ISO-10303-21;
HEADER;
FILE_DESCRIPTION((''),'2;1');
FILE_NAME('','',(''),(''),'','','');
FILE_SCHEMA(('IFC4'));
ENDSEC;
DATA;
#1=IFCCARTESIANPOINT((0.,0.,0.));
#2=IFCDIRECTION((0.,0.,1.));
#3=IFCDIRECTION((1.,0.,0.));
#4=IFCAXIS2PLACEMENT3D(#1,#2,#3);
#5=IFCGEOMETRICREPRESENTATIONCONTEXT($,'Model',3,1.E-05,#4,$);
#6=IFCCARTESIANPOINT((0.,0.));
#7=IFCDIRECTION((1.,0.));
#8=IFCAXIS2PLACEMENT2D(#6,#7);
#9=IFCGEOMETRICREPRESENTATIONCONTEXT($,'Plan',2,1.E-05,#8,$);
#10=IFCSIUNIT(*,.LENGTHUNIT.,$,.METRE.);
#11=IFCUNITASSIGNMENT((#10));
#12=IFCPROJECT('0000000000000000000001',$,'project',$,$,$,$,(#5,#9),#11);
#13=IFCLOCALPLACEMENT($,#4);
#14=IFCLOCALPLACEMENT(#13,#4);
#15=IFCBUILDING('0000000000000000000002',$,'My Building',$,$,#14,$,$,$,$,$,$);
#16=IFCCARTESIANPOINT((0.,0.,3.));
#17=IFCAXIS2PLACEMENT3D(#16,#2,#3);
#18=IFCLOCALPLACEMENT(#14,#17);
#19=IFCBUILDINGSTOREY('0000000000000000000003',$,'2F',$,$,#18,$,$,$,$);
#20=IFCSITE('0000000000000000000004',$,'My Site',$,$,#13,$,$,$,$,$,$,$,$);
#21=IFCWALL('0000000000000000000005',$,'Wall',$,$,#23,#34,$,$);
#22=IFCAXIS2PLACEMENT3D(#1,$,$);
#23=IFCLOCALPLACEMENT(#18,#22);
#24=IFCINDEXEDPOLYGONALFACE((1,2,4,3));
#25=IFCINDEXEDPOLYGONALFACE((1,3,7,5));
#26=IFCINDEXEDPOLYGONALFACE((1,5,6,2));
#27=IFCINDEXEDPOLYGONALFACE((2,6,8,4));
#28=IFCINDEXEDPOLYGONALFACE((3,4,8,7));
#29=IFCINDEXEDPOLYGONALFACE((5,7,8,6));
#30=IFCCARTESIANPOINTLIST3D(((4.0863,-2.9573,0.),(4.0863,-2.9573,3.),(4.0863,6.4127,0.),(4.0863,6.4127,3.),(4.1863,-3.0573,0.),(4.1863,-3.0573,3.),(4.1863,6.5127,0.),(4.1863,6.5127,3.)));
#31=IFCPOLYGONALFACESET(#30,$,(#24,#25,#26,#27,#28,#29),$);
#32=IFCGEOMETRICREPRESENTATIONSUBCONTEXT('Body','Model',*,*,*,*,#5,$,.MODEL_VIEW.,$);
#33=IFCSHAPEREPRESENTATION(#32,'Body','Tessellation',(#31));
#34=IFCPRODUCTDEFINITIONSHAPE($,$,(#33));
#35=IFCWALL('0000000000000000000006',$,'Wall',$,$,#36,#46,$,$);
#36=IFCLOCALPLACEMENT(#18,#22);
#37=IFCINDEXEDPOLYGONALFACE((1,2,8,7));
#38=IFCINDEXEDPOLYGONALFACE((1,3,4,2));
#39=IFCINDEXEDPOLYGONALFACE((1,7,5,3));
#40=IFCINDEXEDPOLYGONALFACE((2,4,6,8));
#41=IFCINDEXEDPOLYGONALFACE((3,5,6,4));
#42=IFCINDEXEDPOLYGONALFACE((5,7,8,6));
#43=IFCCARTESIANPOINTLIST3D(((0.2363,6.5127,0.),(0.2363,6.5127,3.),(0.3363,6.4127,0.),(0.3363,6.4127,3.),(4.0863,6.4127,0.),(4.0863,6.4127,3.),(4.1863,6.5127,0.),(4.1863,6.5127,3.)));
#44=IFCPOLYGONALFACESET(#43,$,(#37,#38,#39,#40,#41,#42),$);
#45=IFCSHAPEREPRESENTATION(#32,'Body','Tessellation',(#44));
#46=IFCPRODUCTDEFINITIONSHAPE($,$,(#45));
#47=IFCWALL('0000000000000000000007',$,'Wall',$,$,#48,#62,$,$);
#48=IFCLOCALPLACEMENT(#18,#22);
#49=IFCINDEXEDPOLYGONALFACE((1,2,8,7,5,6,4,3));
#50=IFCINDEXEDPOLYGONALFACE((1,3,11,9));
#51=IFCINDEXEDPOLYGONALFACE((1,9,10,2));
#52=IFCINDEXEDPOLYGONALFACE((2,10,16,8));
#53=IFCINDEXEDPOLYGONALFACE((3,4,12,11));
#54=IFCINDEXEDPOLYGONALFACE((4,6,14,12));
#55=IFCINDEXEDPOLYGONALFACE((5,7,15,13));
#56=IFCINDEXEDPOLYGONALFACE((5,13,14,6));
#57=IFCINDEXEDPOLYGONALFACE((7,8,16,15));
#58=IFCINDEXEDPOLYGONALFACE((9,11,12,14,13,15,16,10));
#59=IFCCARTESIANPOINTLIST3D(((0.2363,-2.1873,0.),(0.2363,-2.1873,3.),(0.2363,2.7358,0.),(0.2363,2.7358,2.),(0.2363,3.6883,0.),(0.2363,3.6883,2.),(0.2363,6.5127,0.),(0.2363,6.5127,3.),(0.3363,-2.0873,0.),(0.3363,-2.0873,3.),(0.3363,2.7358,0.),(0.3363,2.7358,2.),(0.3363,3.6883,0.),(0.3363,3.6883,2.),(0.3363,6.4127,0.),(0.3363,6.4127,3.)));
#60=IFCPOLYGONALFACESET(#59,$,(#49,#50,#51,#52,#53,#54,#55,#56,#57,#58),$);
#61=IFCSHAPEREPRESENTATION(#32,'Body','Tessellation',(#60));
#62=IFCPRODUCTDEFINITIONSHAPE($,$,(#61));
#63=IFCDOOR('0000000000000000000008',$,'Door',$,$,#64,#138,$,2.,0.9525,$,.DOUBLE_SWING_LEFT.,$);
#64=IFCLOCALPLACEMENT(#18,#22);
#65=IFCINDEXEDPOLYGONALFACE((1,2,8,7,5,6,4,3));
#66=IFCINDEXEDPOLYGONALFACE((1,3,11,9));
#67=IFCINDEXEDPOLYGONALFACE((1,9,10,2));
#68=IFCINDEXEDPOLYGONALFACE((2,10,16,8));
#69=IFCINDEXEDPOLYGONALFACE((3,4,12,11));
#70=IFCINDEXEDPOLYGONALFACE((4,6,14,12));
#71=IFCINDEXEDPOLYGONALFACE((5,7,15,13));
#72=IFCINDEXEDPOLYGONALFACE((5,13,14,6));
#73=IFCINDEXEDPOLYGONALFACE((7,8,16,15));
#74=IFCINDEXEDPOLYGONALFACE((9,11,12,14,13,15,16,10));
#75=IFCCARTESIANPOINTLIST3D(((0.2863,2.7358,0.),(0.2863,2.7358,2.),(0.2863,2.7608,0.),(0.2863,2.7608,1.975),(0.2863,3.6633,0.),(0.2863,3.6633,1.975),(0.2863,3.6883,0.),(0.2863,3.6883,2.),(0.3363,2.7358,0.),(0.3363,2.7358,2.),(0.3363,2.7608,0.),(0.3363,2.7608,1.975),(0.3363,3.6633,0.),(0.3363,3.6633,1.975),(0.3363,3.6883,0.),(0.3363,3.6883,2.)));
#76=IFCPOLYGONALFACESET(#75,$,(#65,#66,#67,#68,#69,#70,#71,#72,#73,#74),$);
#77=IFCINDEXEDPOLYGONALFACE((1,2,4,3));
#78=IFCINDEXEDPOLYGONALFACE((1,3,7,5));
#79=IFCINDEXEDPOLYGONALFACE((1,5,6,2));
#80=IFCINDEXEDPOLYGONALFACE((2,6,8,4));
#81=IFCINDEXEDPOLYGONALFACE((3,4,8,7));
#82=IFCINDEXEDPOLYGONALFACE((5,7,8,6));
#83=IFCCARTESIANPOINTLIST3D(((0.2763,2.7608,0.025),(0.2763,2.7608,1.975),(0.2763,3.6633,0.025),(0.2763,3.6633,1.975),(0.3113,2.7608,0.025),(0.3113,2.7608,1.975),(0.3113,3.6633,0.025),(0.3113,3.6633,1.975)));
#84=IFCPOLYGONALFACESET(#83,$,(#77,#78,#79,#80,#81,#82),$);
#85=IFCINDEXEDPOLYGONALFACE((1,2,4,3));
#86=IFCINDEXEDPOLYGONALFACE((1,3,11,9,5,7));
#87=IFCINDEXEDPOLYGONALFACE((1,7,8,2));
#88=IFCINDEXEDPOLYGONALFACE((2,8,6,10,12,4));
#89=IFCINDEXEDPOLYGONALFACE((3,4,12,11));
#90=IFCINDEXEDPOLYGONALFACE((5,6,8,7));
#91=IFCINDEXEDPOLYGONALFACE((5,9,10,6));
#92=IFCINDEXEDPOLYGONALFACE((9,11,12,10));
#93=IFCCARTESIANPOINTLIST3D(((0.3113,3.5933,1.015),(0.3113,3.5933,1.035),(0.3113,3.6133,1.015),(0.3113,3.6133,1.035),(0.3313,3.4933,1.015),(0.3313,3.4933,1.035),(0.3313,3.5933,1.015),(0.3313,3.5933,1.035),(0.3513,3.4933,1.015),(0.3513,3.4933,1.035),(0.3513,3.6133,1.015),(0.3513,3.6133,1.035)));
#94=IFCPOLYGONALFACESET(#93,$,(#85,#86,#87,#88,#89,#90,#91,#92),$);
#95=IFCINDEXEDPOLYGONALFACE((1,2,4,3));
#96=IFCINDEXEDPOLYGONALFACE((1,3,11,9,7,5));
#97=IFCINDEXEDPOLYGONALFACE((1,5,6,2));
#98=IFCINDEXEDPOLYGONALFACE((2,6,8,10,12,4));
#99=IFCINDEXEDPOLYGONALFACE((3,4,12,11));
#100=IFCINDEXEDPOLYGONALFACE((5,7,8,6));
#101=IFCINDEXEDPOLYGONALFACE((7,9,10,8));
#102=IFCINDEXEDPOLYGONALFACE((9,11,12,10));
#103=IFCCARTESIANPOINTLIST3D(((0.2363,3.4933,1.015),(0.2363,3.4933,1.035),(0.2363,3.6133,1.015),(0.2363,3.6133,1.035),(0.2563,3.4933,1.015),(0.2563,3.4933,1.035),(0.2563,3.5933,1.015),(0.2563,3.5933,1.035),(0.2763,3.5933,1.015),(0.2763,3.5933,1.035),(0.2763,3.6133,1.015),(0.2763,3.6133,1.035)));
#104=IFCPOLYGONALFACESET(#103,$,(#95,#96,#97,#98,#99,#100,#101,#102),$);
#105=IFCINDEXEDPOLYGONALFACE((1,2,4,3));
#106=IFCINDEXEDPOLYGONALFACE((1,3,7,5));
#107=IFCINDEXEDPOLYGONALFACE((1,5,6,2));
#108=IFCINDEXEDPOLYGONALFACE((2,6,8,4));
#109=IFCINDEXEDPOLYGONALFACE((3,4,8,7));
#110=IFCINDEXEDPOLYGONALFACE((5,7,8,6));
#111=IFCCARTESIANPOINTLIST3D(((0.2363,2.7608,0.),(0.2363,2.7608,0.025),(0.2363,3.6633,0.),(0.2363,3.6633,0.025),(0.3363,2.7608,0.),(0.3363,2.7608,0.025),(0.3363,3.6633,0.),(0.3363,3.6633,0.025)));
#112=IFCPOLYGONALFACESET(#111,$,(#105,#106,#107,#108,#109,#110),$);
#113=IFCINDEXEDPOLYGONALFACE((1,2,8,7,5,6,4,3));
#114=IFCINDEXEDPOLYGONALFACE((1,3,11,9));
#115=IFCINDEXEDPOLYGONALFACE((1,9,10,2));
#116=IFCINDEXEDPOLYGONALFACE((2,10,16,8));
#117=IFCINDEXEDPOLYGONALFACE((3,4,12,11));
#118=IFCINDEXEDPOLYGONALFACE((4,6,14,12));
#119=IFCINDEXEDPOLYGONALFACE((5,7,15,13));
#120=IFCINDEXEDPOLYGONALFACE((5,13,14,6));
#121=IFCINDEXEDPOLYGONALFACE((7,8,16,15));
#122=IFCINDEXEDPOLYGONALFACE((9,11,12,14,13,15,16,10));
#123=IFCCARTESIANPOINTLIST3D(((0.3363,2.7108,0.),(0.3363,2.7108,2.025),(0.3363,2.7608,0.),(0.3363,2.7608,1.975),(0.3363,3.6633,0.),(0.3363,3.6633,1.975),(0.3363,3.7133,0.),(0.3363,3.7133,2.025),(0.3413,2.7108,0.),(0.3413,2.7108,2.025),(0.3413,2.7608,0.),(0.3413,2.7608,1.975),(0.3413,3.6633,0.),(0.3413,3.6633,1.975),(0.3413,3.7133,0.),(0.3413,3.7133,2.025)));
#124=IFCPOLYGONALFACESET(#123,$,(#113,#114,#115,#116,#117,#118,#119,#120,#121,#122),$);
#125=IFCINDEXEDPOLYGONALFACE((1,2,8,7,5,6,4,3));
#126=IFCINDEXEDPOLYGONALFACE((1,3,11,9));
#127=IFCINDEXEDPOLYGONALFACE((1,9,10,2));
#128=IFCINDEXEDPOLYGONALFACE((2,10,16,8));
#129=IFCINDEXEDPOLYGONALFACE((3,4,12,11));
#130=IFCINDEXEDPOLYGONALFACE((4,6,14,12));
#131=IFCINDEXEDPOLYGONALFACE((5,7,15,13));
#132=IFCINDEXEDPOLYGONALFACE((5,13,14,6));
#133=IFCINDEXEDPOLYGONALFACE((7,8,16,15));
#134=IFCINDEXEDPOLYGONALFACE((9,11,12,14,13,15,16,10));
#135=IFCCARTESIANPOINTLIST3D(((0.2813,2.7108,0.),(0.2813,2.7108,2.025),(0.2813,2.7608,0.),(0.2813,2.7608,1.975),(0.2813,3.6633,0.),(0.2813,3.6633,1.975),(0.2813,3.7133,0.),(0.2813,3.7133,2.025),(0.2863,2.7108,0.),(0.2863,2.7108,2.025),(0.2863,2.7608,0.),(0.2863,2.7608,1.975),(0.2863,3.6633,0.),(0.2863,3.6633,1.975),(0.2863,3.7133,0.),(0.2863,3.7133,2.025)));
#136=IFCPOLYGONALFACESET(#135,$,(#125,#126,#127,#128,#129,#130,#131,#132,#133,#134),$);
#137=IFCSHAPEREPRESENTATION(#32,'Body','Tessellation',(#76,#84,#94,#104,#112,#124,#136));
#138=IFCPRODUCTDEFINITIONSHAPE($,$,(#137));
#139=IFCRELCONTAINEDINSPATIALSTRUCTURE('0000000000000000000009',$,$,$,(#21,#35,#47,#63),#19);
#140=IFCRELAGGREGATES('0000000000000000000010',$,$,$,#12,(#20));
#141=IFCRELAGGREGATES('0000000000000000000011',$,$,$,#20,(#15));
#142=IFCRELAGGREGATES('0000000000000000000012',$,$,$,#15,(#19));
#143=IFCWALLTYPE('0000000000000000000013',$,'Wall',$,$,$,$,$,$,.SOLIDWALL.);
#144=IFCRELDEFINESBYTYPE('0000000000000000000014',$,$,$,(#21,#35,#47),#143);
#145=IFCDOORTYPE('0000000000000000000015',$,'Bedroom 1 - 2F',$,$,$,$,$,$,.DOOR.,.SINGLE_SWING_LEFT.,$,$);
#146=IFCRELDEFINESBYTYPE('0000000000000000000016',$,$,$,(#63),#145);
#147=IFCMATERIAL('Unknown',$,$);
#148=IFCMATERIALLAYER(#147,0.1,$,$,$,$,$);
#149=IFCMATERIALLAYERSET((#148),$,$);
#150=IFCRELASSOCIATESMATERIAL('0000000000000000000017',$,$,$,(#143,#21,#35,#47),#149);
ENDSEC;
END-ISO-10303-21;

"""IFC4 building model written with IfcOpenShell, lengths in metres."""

from ifc_helpers import new_model, entity, si_unit, frame, origin_with_axes, origin_2d_with_axis, place, context, subcontext, project, spatial, line, indexed_curve, outline, extrude, shape, source, transform, mapped, material, layer, layer_set, layer_usage, type_object, type_shapes, element, fill, save


model = new_model("IFC4")

# Units and contexts
model_context = context("Model", 3, precision=1e-05, world=origin_with_axes())
plan_context = context("Plan", 2, precision=1e-05, world=origin_2d_with_axis())
body_context_1 = subcontext(model_context, "Body", "Model", "MODEL_VIEW")
body_context_2 = subcontext(plan_context, "Body", "Plan", "PLAN_VIEW")
ifc_project = project(units=[si_unit("LENGTHUNIT", "METRE")], contexts=[model_context, plan_context])

# Site, building, storey
site_placement = place(None, origin_with_axes())
site = spatial("IfcSite", under=ifc_project, at=site_placement, Name="My Site")
building_placement = place(site_placement, origin_with_axes())
building = spatial("IfcBuilding", under=site, at=building_placement, Name="My Building")
storey_placement = place(building_placement, frame((0.0, 0.0, 3.0), z_axis=(0.0, 0.0, 1.0), x_axis=(1.0, 0.0, 0.0)))
storey = spatial("IfcBuildingStorey", under=building, at=storey_placement, Name="2F")

# Shared definitions
ifc_material = material(Name="Unknown")

# Shared definitions
ifc_layer_1 = layer(ifc_material, 0.1)
ifc_layer_set_1 = layer_set([ifc_layer_1])
wall_type = type_object("IfcWallType", Name="Wall", PredefinedType="SOLIDWALL", material=ifc_layer_set_1)

# Walls
ifc_layer_usage_1 = layer_usage(ifc_layer_set_1, "AXIS2", "POSITIVE", 0.0)
wall_1_placement = place(storey_placement, frame((4.1863, -3.0573, 0.0), z_axis=(0.0, 0.0, 1.0), x_axis=(0.0, 1.0, 0.0)))
element("IfcWall", 1, at=wall_1_placement, inside=storey, type_object=wall_type, material=ifc_layer_usage_1, Name="Wall", context=body_context_1, shape_type="SweptSolid", body=[
    extrude(outline(indexed_curve([(0.0, 0.0), (0.1, 0.1), (9.47, 0.1), (9.57, 0.0)], segments=[line(1, 2, 3, 4, 1)])), origin_with_axes(), (0.0, 0.0, 1.0), 3.0),
])
ifc_layer_usage_2 = layer_usage(ifc_layer_set_1, "AXIS2", "POSITIVE", 0.0)
wall_2_placement = place(storey_placement, frame((4.1863, 6.5127, 0.0), z_axis=(0.0, 0.0, 1.0), x_axis=(-1.0, 0.0, 0.0)))
element("IfcWall", 2, at=wall_2_placement, inside=storey, type_object=wall_type, material=ifc_layer_usage_2, Name="Wall", context=body_context_1, shape_type="SweptSolid", body=[
    extrude(outline(indexed_curve([(0.0, 0.0), (0.1, 0.1), (3.85, 0.1), (3.95, 0.0)], segments=[line(1, 2, 3, 4, 1)])), origin_with_axes(), (0.0, 0.0, 1.0), 3.0),
])

# Wall, opening, door
ifc_layer_usage_3 = layer_usage(ifc_layer_set_1, "AXIS2", "POSITIVE", 0.0)
wall_3_placement = place(storey_placement, frame((0.2363, 6.5127, 0.0), z_axis=(0.0, 0.0, 1.0), x_axis=(0.0, -1.0, 0.0)))
wall_3 = element("IfcWall", 3, at=wall_3_placement, inside=storey, type_object=wall_type, material=ifc_layer_usage_3, Name="Wall", context=body_context_1, shape_type="SweptSolid", body=[
    extrude(outline(indexed_curve([(0.0, 0.0), (0.1, 0.1), (8.6, 0.1), (8.7, 0.0)], segments=[line(1, 2, 3, 4, 1)])), origin_with_axes(), (0.0, 0.0, 1.0), 3.0),
])
shared_shape_1 = source(origin_with_axes(), body_context_1, "Body", "SweptSolid", [
    extrude(outline(indexed_curve([(0.0, 0.0), (0.9525, 0.0), (0.9525, 2.0), (0.0, 2.0)], segments=[line(1, 2, 3, 4, 1)])), frame((0.0, -0.6, 0.0), z_axis=(0.0, -1.0, 0.0), x_axis=(1.0, 0.0, 0.0)), (0.0, 0.0, -1.0), 1.2),
])
opening_1_placement = place(wall_3_placement, frame((3.7769, 0.1, 0.0), z_axis=(0.0, 0.0, 1.0), x_axis=(-1.0, 0.0, 0.0)))
opening_1 = element("IfcOpeningElement", 4, at=opening_1_placement, cuts=wall_3, PredefinedType="OPENING", context=body_context_1, shape_type="MappedRepresentation", body=[
    mapped(shared_shape_1, transform((0.0, 0.0, 0.0), x_axis=(1.0, 0.0, 0.0), y_axis=(0.0, 1.0, 0.0), z_axis=(0.0, 0.0, 1.0), scale=1.0)),
])
door_type_1 = type_object("IfcDoorType", Name="Bedroom 1 - 2F", OperationType="SINGLE_SWING_LEFT", PredefinedType="DOOR")
shared_shape_2 = source(origin_with_axes(), body_context_1, "Body", "SweptSolid", [
    extrude(outline(indexed_curve([(0.0, 0.0), (0.0, 2.0), (0.9525, 2.0), (0.9525, 0.0), (0.9275, 0.0), (0.9275, 1.975), (0.025, 1.975), (0.025, 0.0)], segments=[line(1, 2, 3, 4, 5, 6, 7, 8, 1)])), frame((0.0, 0.0, 0.0), z_axis=(0.0, -1.0, 0.0), x_axis=(1.0, 0.0, 0.0)), (0.0, 0.0, -1.0), 0.05),
    extrude(outline(indexed_curve([(0.0, 0.0), (0.9025, 0.0), (0.9025, 0.035), (0.0, 0.035)], segments=[line(1, 2, 3, 4, 1)])), frame((0.025, 0.025, 0.025), z_axis=(0.0, 0.0, 1.0), x_axis=(1.0, 0.0, 0.0)), (0.0, 0.0, 1.0), 1.95),
    extrude(outline(indexed_curve([(0.0, 0.0), (0.0, -0.04), (-0.12, -0.04), (-0.12, -0.02), (-0.02, -0.02), (-0.02, 0.0)], segments=[line(1, 2, 3, 4, 5, 6, 1)])), frame((0.8775, 0.025, 1.015), z_axis=(0.0, 0.0, 1.0), x_axis=(1.0, 0.0, 0.0)), (0.0, 0.0, 1.0), 0.02),
    extrude(outline(indexed_curve([(0.0, 0.0), (0.0, 0.04), (-0.12, 0.04), (-0.12, 0.02), (-0.02, 0.02), (-0.02, 0.0)], segments=[line(1, 2, 3, 4, 5, 6, 1)])), frame((0.8775, 0.06, 1.015), z_axis=(0.0, 0.0, 1.0), x_axis=(1.0, 0.0, 0.0)), (0.0, 0.0, 1.0), 0.02),
    extrude(outline(indexed_curve([(0.0, 0.0), (0.9025, 0.0), (0.9025, 0.1), (0.0, 0.1)], segments=[line(1, 2, 3, 4, 1)])), frame((0.025, 0.0, 0.0), z_axis=(0.0, 0.0, 1.0), x_axis=(1.0, 0.0, 0.0)), (0.0, 0.0, 1.0), 0.025),
    extrude(outline(indexed_curve([(0.0, 0.0), (0.0, 2.025), (1.0025, 2.025), (1.0025, 0.0), (0.9525, 0.0), (0.9525, 1.975), (0.05, 1.975), (0.05, 0.0)], segments=[line(1, 2, 3, 4, 5, 6, 7, 8, 1)])), frame((-0.025, -0.005, 0.0), z_axis=(0.0, -1.0, 0.0), x_axis=(1.0, 0.0, 0.0)), (0.0, 0.0, -1.0), 0.005),
    extrude(outline(indexed_curve([(0.0, 0.0), (0.0, 2.025), (1.0025, 2.025), (1.0025, 0.0), (0.9525, 0.0), (0.9525, 1.975), (0.05, 1.975), (0.05, 0.0)], segments=[line(1, 2, 3, 4, 5, 6, 7, 8, 1)])), frame((-0.025, 0.05, 0.0), z_axis=(0.0, -1.0, 0.0), x_axis=(1.0, 0.0, 0.0)), (0.0, 0.0, -1.0), 0.005),
])
shared_shape_3 = source(origin_with_axes(), body_context_2, "Body", "Curve2D", [
    entity("IfcIndexedPolyCurve", entity("IfcCartesianPointList2D", [[0.0, 0.0], [0.025, 0.0], [0.025, 0.05], [0.0, 0.05]]), [entity("IfcLineIndex", [1, 2, 3, 4, 1])]),
    entity("IfcIndexedPolyCurve", entity("IfcCartesianPointList2D", [[0.9525, 0.0], [0.9275, 0.0], [0.9275, 0.05], [0.9525, 0.05]]), [entity("IfcLineIndex", [1, 2, 3, 4, 1])]),
    entity("IfcIndexedPolyCurve", entity("IfcCartesianPointList2D", [[0.025, 0.05], [0.025, -0.8525], [0.06, -0.8525]])),
    entity("IfcTrimmedCurve", entity("IfcEllipse", entity("IfcAxis2Placement2D", entity("IfcCartesianPoint", [0.06, 0.05]), entity("IfcDirection", [1.0, 0.0])), 0.8675, 0.9025), [entity("IfcCartesianPoint", [0.06, -0.8525])], [entity("IfcCartesianPoint", [0.06, 0.9525])], True, "CARTESIAN"),
    entity("IfcIndexedPolyCurve", entity("IfcCartesianPointList2D", [[0.025, 0.05], [0.06, 0.05], [0.06, 0.9525], [0.025, 0.9525]]), [entity("IfcLineIndex", [1, 2, 3, 4, 1])]),
])
type_shapes(door_type_1, [shared_shape_2, shared_shape_3])
door_1_placement = place(opening_1_placement, frame((0.0, 0.0, 0.0), z_axis=(0.0, 0.0, 1.0), x_axis=(1.0, 0.0, 0.0)))
door_1 = element("IfcDoor", 5, at=door_1_placement, inside=storey, type_object=door_type_1, Name="Door", OperationType="DOUBLE_SWING_LEFT", OverallHeight=2.0, OverallWidth=0.9525, shapes=[
    shape(body_context_1, "Body", "MappedRepresentation", [mapped(shared_shape_2, transform((0.0, 0.0, 0.0), x_axis=(1.0, 0.0, 0.0), y_axis=(0.0, 1.0, 0.0), z_axis=(0.0, 0.0, 1.0), scale=1.0))]),
    shape(body_context_2, "Body", "MappedRepresentation", [mapped(shared_shape_3, transform((0.0, 0.0, 0.0), x_axis=(1.0, 0.0, 0.0), y_axis=(0.0, 1.0, 0.0), z_axis=(0.0, 0.0, 1.0), scale=1.0))]),
])
fill(opening_1, door_1)

save(model, "model.ifc")
